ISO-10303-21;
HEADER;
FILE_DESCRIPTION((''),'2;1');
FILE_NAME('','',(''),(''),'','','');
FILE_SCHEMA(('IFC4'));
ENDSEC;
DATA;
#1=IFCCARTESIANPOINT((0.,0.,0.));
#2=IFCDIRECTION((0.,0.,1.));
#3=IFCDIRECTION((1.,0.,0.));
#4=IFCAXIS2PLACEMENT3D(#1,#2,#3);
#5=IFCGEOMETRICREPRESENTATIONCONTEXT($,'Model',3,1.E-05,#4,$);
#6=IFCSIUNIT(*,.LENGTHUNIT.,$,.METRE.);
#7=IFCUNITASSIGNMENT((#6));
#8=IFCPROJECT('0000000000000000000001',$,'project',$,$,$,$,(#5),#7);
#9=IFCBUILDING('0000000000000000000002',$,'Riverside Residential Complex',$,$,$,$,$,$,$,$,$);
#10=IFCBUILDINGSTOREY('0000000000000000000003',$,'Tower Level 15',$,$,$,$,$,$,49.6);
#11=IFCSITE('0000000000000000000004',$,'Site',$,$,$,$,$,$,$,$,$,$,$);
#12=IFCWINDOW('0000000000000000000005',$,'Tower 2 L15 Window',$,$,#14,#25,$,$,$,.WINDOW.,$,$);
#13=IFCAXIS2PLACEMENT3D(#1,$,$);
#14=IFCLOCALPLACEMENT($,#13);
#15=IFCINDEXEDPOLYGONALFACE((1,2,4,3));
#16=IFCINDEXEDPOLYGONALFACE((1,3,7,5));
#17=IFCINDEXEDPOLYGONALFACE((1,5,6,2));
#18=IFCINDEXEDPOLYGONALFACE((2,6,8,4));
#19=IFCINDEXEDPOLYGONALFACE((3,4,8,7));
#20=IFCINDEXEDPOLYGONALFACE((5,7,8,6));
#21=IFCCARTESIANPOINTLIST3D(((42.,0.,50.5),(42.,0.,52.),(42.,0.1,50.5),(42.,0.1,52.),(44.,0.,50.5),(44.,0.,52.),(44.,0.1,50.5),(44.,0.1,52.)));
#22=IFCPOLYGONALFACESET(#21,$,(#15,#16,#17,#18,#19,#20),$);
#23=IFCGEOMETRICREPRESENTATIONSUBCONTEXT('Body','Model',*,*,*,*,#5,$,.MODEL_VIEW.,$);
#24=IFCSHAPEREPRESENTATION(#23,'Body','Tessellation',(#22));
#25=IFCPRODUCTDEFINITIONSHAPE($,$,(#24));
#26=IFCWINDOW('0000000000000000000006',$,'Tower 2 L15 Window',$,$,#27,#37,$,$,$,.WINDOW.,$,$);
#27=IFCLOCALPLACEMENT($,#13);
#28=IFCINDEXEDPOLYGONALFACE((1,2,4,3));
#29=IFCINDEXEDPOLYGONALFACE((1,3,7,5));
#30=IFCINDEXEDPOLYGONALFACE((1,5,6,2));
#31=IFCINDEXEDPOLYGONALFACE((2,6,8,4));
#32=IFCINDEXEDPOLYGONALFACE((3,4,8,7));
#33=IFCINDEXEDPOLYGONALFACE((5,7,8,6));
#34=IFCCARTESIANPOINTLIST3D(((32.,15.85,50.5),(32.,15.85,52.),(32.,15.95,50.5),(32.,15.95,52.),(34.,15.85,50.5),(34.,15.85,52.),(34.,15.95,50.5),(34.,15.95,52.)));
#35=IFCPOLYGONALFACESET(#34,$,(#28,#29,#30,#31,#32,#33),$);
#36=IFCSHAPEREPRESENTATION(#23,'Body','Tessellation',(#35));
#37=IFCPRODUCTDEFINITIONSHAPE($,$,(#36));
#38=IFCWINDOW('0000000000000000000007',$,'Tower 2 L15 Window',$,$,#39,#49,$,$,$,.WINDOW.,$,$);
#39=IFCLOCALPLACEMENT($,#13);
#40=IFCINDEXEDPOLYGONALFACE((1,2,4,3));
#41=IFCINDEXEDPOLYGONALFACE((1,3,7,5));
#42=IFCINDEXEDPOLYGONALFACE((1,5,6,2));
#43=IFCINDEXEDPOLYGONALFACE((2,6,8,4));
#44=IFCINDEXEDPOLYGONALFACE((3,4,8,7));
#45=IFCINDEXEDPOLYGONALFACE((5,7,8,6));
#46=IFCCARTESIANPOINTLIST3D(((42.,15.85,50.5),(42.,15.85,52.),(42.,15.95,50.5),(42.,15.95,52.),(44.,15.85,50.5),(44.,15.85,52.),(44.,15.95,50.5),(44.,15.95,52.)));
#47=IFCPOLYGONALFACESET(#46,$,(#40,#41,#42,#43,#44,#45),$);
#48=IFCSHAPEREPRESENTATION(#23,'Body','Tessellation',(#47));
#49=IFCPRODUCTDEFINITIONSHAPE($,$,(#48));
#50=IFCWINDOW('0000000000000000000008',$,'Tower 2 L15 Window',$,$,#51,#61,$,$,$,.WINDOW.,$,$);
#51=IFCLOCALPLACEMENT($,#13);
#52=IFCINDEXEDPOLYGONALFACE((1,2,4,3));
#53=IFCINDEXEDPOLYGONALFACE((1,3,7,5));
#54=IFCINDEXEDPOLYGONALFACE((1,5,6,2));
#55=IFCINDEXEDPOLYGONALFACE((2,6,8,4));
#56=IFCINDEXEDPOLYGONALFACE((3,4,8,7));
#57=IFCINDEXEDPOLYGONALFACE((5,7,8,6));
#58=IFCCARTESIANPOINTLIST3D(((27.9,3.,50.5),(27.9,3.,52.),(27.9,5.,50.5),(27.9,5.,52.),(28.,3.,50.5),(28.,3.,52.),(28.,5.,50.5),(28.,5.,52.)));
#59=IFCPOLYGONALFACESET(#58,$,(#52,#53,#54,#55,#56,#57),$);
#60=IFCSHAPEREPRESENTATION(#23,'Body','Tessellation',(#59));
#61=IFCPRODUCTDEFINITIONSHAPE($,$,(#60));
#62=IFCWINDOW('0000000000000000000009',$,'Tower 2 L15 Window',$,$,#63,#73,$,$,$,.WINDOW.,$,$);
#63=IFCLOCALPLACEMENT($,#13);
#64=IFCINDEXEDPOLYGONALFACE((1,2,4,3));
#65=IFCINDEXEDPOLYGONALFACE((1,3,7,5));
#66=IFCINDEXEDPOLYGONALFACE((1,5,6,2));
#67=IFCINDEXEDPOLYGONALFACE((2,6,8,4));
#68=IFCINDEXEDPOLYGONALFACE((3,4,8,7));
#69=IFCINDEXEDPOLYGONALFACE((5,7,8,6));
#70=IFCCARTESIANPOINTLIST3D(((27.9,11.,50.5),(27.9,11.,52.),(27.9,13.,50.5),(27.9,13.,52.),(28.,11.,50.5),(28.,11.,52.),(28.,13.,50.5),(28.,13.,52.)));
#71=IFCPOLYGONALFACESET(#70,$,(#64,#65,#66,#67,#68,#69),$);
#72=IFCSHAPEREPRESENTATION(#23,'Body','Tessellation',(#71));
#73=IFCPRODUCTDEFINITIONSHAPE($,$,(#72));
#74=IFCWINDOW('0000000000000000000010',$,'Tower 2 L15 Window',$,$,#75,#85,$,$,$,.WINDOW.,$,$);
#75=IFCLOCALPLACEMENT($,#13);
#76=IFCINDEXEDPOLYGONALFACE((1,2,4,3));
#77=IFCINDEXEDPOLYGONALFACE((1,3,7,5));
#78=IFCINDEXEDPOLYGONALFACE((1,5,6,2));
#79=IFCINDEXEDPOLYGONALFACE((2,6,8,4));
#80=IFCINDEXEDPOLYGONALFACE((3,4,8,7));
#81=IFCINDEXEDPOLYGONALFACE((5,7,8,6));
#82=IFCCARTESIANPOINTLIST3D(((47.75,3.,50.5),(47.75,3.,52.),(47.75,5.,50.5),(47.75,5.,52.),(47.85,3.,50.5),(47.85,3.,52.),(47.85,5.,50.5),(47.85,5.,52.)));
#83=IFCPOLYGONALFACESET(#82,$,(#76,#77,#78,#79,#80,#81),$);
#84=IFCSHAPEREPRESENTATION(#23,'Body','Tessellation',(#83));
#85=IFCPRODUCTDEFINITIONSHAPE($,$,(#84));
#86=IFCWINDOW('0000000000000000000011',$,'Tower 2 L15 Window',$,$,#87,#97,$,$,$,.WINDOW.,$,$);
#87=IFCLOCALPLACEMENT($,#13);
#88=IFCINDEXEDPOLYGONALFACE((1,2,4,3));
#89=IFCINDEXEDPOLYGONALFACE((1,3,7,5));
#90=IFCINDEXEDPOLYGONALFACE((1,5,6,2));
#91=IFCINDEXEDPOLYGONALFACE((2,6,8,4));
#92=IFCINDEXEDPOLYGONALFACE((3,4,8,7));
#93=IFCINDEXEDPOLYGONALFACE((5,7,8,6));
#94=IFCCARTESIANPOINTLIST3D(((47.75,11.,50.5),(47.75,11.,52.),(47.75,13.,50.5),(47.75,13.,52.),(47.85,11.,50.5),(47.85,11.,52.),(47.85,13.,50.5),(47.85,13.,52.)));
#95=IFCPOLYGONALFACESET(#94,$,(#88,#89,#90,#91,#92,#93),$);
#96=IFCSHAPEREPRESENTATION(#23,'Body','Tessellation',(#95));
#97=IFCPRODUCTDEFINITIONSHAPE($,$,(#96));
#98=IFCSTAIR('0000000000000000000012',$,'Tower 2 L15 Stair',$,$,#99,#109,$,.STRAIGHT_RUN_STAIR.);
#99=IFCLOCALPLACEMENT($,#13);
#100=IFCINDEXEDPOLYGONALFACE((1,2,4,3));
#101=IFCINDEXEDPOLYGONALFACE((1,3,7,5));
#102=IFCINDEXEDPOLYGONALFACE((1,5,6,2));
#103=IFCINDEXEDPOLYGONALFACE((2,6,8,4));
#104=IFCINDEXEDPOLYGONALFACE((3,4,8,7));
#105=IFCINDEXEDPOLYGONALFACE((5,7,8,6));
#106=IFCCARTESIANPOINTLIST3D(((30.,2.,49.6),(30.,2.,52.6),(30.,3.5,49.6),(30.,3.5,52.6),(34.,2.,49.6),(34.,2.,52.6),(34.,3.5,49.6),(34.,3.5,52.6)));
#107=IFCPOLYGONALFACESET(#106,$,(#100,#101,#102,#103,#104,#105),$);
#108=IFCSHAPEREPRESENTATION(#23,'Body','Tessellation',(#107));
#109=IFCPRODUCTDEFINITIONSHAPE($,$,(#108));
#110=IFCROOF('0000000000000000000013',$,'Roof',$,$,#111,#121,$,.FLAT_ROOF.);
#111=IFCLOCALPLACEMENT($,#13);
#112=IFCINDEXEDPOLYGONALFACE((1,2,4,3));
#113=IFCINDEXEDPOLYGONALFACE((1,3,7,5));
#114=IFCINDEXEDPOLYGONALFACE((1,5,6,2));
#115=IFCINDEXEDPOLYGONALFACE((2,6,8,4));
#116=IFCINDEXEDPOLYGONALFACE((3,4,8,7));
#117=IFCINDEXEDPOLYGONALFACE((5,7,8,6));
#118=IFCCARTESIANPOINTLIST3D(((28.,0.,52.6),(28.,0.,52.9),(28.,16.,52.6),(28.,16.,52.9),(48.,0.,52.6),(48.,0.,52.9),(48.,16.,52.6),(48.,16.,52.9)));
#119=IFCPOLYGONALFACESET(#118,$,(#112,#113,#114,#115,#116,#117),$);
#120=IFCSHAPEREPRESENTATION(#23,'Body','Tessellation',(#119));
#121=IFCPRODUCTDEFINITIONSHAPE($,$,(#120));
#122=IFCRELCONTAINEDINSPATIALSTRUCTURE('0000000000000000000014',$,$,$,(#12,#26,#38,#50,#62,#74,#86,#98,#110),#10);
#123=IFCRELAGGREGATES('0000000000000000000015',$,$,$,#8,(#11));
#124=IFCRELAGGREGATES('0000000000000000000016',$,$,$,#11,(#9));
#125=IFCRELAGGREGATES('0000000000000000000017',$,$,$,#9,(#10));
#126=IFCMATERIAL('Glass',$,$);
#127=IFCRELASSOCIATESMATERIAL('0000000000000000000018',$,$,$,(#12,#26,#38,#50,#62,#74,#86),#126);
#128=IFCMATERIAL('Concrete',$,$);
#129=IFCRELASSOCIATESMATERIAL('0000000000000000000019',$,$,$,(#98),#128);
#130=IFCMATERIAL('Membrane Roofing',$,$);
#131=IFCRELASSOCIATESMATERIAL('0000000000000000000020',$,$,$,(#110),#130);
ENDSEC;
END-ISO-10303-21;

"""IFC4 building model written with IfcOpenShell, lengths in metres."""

from ifc_helpers import new_model, si_unit, frame, origin_with_axes, place, context, subcontext, project, spatial, line, indexed_curve, outline, extrude, material, element, save


model = new_model("IFC4")

# Units and contexts
model_context = context("Model", 3, precision=1e-05, world=origin_with_axes())
body_context = subcontext(model_context, "Body", "Model", "MODEL_VIEW")
ifc_project = project(units=[si_unit("LENGTHUNIT", "METRE")], contexts=[model_context])

# Site, building, storey
site = spatial("IfcSite", under=ifc_project, Name="Site")
building = spatial("IfcBuilding", under=site, Name="Riverside Residential Complex")
storey = spatial("IfcBuildingStorey", under=building, Name="Tower Level 15", Elevation=49.6)

# Shared definitions
ifc_material_1 = material(Name="Concrete")

# Windows
ifc_material_2 = material(Name="Glass")
for number, where, z_axis, x_axis, name in (
    (1, (42.0, 0.0, 50.5), (0.0, 0.0, 1.0), (1.0, 0.0, 0.0), "Tower 2 L15 Window"),
    (2, (32.0, 15.85, 50.5), (0.0, 0.0, 1.0), (1.0, 0.0, 0.0), "Tower 2 L15 Window"),
    (3, (42.0, 15.85, 50.5), (0.0, 0.0, 1.0), (1.0, 0.0, 0.0), "Tower 2 L15 Window"),
    (4, (28.0, 3.0, 50.5), (0.0, 0.0, 1.0), (0.0, 1.0, 0.0), "Tower 2 L15 Window"),
    (5, (28.0, 11.0, 50.5), (0.0, 0.0, 1.0), (0.0, 1.0, 0.0), "Tower 2 L15 Window"),
    (6, (47.85, 3.0, 50.5), (0.0, 0.0, 1.0), (0.0, 1.0, 0.0), "Tower 2 L15 Window"),
    (7, (47.85, 11.0, 50.5), (0.0, 0.0, 1.0), (0.0, 1.0, 0.0), "Tower 2 L15 Window"),
):
    element("IfcWindow", number, at=place(None, frame(where, z_axis=z_axis, x_axis=x_axis)), inside=storey, material=ifc_material_2, Name=name, PredefinedType="WINDOW", context=body_context, shape_type="SweptSolid", body=[
        extrude(outline(indexed_curve([(0.0, 0.0), (2.0, 0.0), (2.0, 0.1), (0.0, 0.1)], segments=[line(1, 2, 3, 4, 1)])), origin_with_axes(), (0.0, 0.0, 1.0), 1.5),
    ])

# Stair
stair_placement = place(None, frame((30.0, 2.0, 49.6), z_axis=(0.0, 0.0, 1.0), x_axis=(1.0, 0.0, 0.0)))
element("IfcStair", 8, at=stair_placement, inside=storey, material=ifc_material_1, Name="Tower 2 L15 Stair", PredefinedType="STRAIGHT_RUN_STAIR", context=body_context, shape_type="SweptSolid", body=[
    extrude(outline(indexed_curve([(0.0, 0.0), (4.0, 0.0), (4.0, 1.5), (0.0, 1.5)], segments=[line(1, 2, 3, 4, 1)])), origin_with_axes(), (0.0, 0.0, 1.0), 3.0),
])

# Roof
ifc_material_3 = material(Name="Membrane Roofing")
roof_placement = place(None, frame((28.0, 0.0, 52.6), z_axis=(0.0, 0.0, 1.0), x_axis=(1.0, 0.0, 0.0)))
element("IfcRoof", 9, at=roof_placement, inside=storey, material=ifc_material_3, Name="Roof", PredefinedType="FLAT_ROOF", context=body_context, shape_type="SweptSolid", body=[
    extrude(outline(indexed_curve([(0.0, 0.0), (20.0, 0.0), (20.0, 16.0), (0.0, 16.0)], segments=[line(1, 2, 3, 4, 1)])), origin_with_axes(), (0.0, 0.0, 1.0), 0.3),
])

save(model, "model.ifc")
